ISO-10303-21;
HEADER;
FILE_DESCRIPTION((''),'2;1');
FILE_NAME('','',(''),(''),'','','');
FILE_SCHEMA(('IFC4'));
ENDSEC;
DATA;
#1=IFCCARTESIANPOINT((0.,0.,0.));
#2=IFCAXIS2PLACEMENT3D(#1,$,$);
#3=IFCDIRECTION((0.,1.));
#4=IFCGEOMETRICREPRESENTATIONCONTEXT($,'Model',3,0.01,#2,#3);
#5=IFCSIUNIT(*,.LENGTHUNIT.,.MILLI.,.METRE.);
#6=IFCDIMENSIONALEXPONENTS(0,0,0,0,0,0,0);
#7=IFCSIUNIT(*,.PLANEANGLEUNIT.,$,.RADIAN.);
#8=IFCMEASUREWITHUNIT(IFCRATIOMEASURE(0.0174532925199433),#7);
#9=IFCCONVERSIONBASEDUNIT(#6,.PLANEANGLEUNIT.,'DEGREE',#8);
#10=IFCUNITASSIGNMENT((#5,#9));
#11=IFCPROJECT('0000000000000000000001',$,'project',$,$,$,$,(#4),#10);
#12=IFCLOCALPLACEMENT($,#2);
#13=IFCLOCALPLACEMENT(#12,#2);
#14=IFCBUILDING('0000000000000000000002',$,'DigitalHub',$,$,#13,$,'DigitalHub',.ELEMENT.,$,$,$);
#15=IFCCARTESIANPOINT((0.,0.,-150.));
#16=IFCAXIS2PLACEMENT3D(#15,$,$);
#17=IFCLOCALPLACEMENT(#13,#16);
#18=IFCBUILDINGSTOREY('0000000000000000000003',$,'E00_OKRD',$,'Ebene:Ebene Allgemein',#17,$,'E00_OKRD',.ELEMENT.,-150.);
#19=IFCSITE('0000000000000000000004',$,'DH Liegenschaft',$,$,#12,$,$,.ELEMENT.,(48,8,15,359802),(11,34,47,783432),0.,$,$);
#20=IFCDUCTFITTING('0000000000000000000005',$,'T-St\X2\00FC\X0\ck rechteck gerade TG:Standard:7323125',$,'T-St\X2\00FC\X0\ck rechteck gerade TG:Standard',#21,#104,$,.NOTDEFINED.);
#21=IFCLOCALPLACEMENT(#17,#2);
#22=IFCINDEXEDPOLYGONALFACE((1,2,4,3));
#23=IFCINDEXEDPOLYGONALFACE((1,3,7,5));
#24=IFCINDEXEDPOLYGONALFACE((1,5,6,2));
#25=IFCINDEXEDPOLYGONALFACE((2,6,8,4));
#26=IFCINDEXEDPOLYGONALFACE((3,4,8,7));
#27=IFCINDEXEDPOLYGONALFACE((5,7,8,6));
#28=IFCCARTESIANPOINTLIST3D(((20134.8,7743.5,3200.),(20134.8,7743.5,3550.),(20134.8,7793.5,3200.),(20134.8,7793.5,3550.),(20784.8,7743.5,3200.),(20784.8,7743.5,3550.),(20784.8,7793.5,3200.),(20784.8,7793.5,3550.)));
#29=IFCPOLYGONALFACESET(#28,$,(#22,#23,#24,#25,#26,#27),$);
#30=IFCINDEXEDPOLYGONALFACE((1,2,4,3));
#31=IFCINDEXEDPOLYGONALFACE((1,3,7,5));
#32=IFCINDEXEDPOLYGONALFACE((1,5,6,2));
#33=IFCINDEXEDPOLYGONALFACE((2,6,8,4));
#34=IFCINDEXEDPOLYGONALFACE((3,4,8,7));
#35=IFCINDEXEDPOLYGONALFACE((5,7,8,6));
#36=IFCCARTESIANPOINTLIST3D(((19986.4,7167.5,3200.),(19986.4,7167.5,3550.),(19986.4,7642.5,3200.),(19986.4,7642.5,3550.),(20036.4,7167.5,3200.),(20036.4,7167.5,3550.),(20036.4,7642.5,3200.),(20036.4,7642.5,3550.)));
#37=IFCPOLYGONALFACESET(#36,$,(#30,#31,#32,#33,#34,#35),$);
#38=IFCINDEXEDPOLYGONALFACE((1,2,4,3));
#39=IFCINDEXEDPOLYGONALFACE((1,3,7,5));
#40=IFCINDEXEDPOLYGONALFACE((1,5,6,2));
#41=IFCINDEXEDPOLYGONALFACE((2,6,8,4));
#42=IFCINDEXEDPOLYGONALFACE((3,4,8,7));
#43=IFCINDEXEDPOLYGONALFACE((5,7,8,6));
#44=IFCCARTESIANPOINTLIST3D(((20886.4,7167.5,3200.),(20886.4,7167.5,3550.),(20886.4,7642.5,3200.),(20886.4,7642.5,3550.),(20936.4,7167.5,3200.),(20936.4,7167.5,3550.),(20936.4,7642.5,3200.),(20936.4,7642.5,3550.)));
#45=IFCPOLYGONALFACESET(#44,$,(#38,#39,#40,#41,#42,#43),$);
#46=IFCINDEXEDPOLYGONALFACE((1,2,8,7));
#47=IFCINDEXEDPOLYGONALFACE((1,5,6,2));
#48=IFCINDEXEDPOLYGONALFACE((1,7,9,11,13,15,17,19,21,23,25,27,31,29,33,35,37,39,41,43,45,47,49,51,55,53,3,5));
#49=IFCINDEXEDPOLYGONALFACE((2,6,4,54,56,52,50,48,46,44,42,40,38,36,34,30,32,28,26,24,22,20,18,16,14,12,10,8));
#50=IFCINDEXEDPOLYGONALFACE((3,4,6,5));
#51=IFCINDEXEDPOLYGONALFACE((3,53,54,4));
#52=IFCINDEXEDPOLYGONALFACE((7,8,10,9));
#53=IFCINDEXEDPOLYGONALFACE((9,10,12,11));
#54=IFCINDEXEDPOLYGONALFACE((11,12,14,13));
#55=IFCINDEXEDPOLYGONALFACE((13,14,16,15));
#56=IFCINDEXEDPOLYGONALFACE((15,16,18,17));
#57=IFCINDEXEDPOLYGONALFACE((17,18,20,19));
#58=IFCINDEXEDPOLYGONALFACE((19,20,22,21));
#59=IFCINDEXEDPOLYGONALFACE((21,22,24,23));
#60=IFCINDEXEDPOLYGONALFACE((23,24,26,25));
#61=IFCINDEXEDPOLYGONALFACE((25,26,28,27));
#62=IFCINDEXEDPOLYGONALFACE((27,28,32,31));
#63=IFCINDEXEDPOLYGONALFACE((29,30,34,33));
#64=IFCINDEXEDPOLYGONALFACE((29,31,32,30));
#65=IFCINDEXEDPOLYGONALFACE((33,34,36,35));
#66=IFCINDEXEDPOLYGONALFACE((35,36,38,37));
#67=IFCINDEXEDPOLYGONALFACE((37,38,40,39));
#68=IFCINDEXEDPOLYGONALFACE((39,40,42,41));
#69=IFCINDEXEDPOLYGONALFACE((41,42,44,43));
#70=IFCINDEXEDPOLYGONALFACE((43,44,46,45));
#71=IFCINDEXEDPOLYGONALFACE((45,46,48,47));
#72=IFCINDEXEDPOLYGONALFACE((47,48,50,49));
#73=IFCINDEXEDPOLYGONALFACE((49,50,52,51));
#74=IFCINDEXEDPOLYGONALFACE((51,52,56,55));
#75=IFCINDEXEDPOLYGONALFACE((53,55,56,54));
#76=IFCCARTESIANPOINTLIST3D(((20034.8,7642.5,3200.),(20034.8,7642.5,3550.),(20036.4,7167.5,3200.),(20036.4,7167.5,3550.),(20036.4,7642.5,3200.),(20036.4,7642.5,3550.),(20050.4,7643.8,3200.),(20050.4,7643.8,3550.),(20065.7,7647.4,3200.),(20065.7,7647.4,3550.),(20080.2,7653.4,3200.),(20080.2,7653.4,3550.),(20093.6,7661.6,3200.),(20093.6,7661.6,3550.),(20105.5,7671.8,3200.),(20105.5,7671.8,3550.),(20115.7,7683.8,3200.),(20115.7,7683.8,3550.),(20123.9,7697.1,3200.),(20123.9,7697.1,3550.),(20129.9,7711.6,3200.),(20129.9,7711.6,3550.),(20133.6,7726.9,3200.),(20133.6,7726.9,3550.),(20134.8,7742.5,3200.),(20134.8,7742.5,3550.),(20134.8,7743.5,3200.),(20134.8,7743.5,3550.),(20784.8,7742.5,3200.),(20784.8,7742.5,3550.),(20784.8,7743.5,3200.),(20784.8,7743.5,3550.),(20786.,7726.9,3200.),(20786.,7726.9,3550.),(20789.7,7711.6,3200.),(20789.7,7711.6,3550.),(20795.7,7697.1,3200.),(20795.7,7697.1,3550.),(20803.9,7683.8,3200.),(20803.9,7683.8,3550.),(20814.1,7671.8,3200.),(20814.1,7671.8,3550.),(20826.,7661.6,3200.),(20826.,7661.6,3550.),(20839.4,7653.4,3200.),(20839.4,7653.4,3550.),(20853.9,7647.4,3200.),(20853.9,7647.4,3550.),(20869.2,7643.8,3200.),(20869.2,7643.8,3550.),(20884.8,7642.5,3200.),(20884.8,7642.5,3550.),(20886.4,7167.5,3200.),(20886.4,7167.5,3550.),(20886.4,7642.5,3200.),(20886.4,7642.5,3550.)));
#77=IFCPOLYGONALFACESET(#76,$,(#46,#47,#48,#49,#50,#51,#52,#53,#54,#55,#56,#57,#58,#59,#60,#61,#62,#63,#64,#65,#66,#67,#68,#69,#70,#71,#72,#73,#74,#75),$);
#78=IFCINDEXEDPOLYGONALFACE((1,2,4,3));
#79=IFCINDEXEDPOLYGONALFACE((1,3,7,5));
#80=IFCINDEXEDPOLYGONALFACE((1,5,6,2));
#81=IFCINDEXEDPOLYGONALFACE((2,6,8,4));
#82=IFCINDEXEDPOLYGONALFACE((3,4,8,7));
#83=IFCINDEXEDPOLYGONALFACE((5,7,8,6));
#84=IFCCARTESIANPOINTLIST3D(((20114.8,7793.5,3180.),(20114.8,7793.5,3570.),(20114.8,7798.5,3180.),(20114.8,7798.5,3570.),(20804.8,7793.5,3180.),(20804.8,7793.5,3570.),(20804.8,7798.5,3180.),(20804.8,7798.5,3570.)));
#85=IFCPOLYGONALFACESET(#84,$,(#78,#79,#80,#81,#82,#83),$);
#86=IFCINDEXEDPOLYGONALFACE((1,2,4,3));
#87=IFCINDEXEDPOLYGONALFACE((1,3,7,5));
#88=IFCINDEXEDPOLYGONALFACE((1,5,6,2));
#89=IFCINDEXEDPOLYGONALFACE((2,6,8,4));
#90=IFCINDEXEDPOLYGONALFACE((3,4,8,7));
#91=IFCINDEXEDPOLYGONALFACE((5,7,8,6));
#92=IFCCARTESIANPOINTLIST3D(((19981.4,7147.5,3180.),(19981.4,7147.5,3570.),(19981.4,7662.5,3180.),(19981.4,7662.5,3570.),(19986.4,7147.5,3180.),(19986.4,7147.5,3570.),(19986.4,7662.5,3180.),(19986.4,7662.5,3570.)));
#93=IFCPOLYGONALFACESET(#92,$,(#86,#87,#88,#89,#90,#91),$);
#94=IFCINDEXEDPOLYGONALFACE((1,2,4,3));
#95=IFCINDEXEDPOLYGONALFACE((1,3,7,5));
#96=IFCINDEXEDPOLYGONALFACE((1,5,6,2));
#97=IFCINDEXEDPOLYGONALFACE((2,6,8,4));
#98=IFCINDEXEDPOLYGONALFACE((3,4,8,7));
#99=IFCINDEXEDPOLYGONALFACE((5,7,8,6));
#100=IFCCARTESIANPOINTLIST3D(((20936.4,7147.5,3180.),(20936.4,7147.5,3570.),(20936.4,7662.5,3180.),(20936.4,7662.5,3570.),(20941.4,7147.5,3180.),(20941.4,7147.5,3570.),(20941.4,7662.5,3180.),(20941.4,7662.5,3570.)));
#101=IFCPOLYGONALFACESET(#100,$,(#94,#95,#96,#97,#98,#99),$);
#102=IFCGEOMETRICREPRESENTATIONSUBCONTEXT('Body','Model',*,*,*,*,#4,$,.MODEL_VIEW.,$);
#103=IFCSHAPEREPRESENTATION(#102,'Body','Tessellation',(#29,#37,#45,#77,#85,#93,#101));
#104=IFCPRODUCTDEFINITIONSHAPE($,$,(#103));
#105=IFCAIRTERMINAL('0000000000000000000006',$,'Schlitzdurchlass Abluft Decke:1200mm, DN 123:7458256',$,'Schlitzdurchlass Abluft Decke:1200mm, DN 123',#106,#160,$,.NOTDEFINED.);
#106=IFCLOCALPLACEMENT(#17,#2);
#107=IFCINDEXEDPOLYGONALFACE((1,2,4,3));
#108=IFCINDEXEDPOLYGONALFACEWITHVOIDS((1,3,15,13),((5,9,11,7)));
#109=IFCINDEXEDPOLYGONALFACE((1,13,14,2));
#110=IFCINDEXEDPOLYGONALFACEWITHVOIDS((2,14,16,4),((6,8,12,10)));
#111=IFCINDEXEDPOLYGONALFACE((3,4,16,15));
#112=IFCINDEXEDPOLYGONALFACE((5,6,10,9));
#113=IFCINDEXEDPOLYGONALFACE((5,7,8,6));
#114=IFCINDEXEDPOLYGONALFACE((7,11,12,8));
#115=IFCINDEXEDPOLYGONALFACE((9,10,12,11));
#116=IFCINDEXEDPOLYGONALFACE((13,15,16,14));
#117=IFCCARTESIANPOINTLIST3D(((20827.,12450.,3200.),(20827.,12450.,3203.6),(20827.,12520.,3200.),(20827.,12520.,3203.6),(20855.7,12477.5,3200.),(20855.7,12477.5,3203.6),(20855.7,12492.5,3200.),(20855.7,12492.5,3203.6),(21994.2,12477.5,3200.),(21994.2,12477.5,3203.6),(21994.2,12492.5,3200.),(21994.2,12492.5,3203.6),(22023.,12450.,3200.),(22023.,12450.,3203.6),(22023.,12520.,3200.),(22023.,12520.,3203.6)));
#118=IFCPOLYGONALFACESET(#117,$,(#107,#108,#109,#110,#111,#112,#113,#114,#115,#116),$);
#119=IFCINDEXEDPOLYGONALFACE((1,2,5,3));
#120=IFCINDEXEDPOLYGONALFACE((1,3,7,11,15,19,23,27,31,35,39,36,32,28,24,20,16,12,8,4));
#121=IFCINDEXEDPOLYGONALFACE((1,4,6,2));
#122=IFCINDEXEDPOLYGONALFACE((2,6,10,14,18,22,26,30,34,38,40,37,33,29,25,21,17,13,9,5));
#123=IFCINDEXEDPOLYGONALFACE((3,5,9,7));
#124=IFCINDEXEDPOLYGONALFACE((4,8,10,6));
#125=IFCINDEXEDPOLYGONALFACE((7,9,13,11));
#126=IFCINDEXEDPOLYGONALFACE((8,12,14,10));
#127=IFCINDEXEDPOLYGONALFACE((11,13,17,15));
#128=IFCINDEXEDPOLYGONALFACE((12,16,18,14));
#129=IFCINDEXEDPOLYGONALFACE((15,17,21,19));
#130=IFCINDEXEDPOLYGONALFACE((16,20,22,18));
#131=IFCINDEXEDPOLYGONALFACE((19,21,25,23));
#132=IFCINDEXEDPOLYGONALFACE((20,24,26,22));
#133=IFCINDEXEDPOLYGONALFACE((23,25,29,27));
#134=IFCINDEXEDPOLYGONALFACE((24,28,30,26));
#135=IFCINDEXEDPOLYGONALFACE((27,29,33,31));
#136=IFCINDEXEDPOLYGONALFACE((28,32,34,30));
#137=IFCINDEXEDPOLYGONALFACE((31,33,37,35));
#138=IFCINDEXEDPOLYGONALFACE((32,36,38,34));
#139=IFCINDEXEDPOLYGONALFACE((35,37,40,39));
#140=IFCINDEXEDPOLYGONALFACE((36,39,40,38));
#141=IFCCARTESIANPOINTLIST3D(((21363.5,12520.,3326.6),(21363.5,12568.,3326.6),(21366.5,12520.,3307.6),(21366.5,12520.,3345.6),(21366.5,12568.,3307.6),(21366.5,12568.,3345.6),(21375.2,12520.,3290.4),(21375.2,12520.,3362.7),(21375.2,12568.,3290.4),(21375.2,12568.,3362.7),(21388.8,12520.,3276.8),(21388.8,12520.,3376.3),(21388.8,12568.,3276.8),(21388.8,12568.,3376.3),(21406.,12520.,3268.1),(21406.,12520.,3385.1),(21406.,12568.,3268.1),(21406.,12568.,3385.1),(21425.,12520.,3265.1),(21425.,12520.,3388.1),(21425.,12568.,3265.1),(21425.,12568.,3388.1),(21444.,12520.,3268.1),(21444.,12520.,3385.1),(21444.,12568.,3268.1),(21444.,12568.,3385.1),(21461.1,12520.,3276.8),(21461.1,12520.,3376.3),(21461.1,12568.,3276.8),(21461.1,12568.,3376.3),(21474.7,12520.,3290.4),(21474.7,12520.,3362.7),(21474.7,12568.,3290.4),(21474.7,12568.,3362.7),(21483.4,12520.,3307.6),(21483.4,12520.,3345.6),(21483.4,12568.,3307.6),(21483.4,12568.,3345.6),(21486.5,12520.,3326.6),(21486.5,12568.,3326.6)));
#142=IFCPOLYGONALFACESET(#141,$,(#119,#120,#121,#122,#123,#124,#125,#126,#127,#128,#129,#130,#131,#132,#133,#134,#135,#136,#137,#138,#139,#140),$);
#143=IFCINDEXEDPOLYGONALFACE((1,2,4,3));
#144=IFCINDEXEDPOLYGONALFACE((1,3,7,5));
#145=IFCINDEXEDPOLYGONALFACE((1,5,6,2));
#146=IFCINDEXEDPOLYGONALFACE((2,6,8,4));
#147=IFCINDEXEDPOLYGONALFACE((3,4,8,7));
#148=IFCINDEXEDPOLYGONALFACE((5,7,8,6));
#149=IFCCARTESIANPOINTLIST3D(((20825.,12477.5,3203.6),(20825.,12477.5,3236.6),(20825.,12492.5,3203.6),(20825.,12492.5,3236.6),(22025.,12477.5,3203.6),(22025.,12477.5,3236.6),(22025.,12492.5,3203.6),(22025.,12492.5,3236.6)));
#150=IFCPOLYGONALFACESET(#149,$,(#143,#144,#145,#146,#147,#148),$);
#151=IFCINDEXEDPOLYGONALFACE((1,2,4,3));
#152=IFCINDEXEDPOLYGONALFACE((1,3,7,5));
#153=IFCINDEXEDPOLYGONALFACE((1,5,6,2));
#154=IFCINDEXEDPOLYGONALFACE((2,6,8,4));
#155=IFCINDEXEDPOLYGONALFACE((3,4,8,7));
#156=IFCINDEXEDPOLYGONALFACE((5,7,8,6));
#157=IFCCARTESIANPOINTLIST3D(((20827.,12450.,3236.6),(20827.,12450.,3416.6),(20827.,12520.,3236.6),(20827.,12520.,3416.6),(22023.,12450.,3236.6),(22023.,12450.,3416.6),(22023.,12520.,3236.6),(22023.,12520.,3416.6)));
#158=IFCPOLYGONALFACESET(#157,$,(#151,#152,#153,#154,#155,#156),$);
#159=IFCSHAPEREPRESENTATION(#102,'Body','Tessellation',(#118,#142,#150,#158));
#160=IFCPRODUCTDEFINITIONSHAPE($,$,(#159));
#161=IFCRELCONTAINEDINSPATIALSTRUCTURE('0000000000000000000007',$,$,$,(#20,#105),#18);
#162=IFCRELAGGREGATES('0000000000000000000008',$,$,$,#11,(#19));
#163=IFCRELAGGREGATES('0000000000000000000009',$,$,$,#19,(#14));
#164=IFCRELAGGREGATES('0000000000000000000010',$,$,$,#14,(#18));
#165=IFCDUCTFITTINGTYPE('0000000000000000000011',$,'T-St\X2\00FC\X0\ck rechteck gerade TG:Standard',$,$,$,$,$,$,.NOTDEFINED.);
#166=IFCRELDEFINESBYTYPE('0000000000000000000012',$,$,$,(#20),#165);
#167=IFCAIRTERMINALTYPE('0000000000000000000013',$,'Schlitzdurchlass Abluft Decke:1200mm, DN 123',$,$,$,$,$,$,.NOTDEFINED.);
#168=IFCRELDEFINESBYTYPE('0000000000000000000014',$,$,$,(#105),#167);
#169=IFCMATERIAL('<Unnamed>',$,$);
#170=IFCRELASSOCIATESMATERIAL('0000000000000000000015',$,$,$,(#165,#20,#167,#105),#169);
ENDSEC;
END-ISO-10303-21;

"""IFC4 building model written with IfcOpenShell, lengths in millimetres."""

from ifc_helpers import new_model, entity, si_unit, converted_unit, direction, frame, origin, place, context, subcontext, project, spatial, indexed_curve, outline, extrude, source, transform, mapped, material, type_object, type_shapes, element, save


model = new_model("IFC4")

# Units and contexts
model_context = context("Model", 3, precision=0.01, world=origin(), true_north=direction((0.0, 1.0)))
body_context = subcontext(model_context, "Body", "Model", "MODEL_VIEW")
ifc_project = project(units=[si_unit("LENGTHUNIT", "METRE", prefix="MILLI"), converted_unit("PLANEANGLEUNIT", "DEGREE", entity("IfcRatioMeasure", 0.0174532925199433), si_unit("PLANEANGLEUNIT", "RADIAN"), dimensions=[0, 0, 0, 0, 0, 0, 0])], contexts=[model_context])

# Site, building, storey
site_placement = place(None, origin())
site = spatial("IfcSite", under=ifc_project, at=site_placement, Name="DH Liegenschaft", CompositionType="ELEMENT", RefLatitude=(48, 8, 15, 359802), RefLongitude=(11, 34, 47, 783432), RefElevation=0.0)
building_placement = place(site_placement, origin())
building = spatial("IfcBuilding", under=site, at=building_placement, Name="DigitalHub", LongName="DigitalHub", CompositionType="ELEMENT")
storey_placement = place(building_placement, frame((0.0, 0.0, -150.0)))
storey = spatial("IfcBuildingStorey", under=building, at=storey_placement, Name="E00_OKRD", ObjectType="Ebene:Ebene Allgemein", LongName="E00_OKRD", CompositionType="ELEMENT", Elevation=-150.0)

# Shared definitions
ifc_material_1 = material(Name="<Unnamed>")

# Duct fitting
duct_fitting_type_1 = type_object("IfcDuctFittingType", Name="T-Stück rechteck gerade TG:Standard", PredefinedType="NOTDEFINED", material=ifc_material_1)
shared_shape_1 = source(origin(), body_context, "Body", "SweptSolid", [
    extrude(outline(indexed_curve([(-25.0, -325.0), (25.0, -325.0), (25.0, 325.0), (-25.0, 325.0), (-25.0, -325.0)], self_intersect=False)), frame((0.0, -363.5, -175.0), z_axis=(0.0, 0.0, 1.0), x_axis=(0.0, -1.0, 0.0)), (0.0, 0.0, 1.0), 350.0),
    extrude(outline(indexed_curve([(-25.0, -237.5), (25.0, -237.5), (25.0, 237.5), (-25.0, 237.5), (-25.0, -237.5)], self_intersect=False)), frame((448.4, 0.0, -175.0), z_axis=(0.0, 0.0, 1.0), x_axis=(-1.0, 0.0, 0.0)), (0.0, 0.0, 1.0), 350.0),
    extrude(outline(indexed_curve([(-25.0, -237.5), (25.0, -237.5), (25.0, 237.5), (-25.0, 237.5), (-25.0, -237.5)], self_intersect=False)), frame((-451.6, 0.0, -175.0)), (0.0, 0.0, 1.0), 350.0),
    extrude(outline(indexed_curve([(-425.6, -54.8), (-410.0, -56.0), (-394.7, -59.7), (-380.2, -65.7), (-366.9, -73.9), (-354.9, -84.1), (-344.7, -96.0), (-336.5, -109.4), (-330.5, -123.9), (-326.9, -139.2), (-325.6, -154.8), (-325.6, -155.8), (324.4, -155.8), (324.4, -154.8), (325.6, -139.2), (329.3, -123.9), (335.3, -109.4), (343.5, -96.0), (353.6, -84.1), (365.6, -73.9), (379.0, -65.7), (393.5, -59.7), (408.7, -56.0), (424.4, -54.8), (426.0, -54.8), (426.0, 420.2), (-424.0, 420.2), (-424.0, -54.8), (-425.6, -54.8)], self_intersect=False)), frame((-0.6, -182.7, -175.0), z_axis=(0.0, 0.0, -1.0), x_axis=(-1.0, 0.0, 0.0)), (0.0, 0.0, -1.0), 350.0),
    extrude(outline(indexed_curve([(-2.5, -345.0), (2.5, -345.0), (2.5, 345.0), (-2.5, 345.0), (-2.5, -345.0)], self_intersect=False)), frame((0.0, -391.0, -195.0), z_axis=(0.0, 0.0, 1.0), x_axis=(0.0, 1.0, 0.0)), (0.0, 0.0, 1.0), 390.0),
    extrude(outline(indexed_curve([(-2.5, -257.5), (2.5, -257.5), (2.5, 257.5), (-2.5, 257.5), (-2.5, -257.5)], self_intersect=False)), frame((475.9, 0.0, -195.0), z_axis=(0.0, 0.0, 1.0), x_axis=(-1.0, 0.0, 0.0)), (0.0, 0.0, 1.0), 390.0),
    extrude(outline(indexed_curve([(-2.5, -257.5), (2.5, -257.5), (2.5, 257.5), (-2.5, 257.5), (-2.5, -257.5)], self_intersect=False)), frame((-479.1, 0.0, -195.0), z_axis=(0.0, 0.0, 1.0), x_axis=(-1.0, 0.0, 0.0)), (0.0, 0.0, 1.0), 390.0),
])
type_shapes(duct_fitting_type_1, [shared_shape_1])
duct_fitting_1_placement = place(storey_placement, frame((20459.8, 7405.0, 3375.0), z_axis=(0.0, 0.0, 1.0), x_axis=(-1.0, 0.0, 0.0)))
element("IfcDuctFitting", 1, at=duct_fitting_1_placement, inside=storey, type_object=duct_fitting_type_1, material=ifc_material_1, Name="T-Stück rechteck gerade TG:Standard:7323125", ObjectType="T-Stück rechteck gerade TG:Standard", PredefinedType="NOTDEFINED", context=body_context, shape_type="MappedRepresentation", body=[
    mapped(shared_shape_1, transform((0.0, 0.0, 0.0), scale=1.0)),
])

# Air terminal
air_terminal_type_1 = type_object("IfcAirTerminalType", Name="Schlitzdurchlass Abluft Decke:1200mm, DN 123", PredefinedType="NOTDEFINED", material=ifc_material_1)
shared_shape_2 = source(origin(), body_context, "Body", "SweptSolid", [
    extrude(outline(indexed_curve([(-598.0, -35.0), (598.0, -35.0), (598.0, 35.0), (-598.0, 35.0), (-598.0, -35.0)], self_intersect=False), holes=[indexed_curve([(-569.2, -7.5), (-569.2, 7.5), (569.2, 7.5), (569.2, -7.5), (-569.2, -7.5)], self_intersect=False)]), frame((0.0, 0.0, 0.0), z_axis=(0.0, 0.0, 1.0), x_axis=(-1.0, 0.0, 0.0)), (0.0, 0.0, 1.0), 3.6),
    extrude(outline(indexed_curve([(61.5, 0.0), (58.5, 19.0), (49.8, 36.1), (36.1, 49.8), (19.0, 58.5), (0.0, 61.5), (-19.0, 58.5), (-36.1, 49.8), (-49.8, 36.1), (-58.5, 19.0), (-61.5, 0.0), (-58.5, -19.0), (-49.8, -36.1), (-36.1, -49.8), (-19.0, -58.5), (0.0, -61.5), (19.0, -58.5), (36.1, -49.8), (49.8, -36.1), (58.5, -19.0), (61.5, 0.0)], self_intersect=False)), frame((0.0, 35.0, 126.6), z_axis=(0.0, 1.0, 0.0), x_axis=(-1.0, 0.0, 0.0)), (0.0, 0.0, 1.0), 48.0),
    extrude(outline(indexed_curve([(-600.0, -7.5), (600.0, -7.5), (600.0, 7.5), (-600.0, 7.5), (-600.0, -7.5)], self_intersect=False)), frame((0.0, 0.0, 3.6), z_axis=(0.0, 0.0, 1.0), x_axis=(-1.0, 0.0, 0.0)), (0.0, 0.0, 1.0), 33.0),
    extrude(outline(indexed_curve([(-598.0, -35.0), (598.0, -35.0), (598.0, 35.0), (-598.0, 35.0), (-598.0, -35.0)], self_intersect=False)), frame((0.0, 0.0, 36.6), z_axis=(0.0, 0.0, 1.0), x_axis=(-1.0, 0.0, 0.0)), (0.0, 0.0, 1.0), 180.0),
])
type_shapes(air_terminal_type_1, [shared_shape_2])
for number, where, name in (
    (2, (21425.0, 12485.0, 3200.0), "Schlitzdurchlass Abluft Decke:1200mm, DN 123:7458256"),
):
    element("IfcAirTerminal", number, at=place(storey_placement, frame(where)), inside=storey, type_object=air_terminal_type_1, material=ifc_material_1, Name=name, ObjectType="Schlitzdurchlass Abluft Decke:1200mm, DN 123", PredefinedType="NOTDEFINED", context=body_context, shape_type="MappedRepresentation", body=[
        mapped(shared_shape_2, transform((0.0, 0.0, 0.0), scale=1.0)),
    ])

save(model, "model.ifc")
